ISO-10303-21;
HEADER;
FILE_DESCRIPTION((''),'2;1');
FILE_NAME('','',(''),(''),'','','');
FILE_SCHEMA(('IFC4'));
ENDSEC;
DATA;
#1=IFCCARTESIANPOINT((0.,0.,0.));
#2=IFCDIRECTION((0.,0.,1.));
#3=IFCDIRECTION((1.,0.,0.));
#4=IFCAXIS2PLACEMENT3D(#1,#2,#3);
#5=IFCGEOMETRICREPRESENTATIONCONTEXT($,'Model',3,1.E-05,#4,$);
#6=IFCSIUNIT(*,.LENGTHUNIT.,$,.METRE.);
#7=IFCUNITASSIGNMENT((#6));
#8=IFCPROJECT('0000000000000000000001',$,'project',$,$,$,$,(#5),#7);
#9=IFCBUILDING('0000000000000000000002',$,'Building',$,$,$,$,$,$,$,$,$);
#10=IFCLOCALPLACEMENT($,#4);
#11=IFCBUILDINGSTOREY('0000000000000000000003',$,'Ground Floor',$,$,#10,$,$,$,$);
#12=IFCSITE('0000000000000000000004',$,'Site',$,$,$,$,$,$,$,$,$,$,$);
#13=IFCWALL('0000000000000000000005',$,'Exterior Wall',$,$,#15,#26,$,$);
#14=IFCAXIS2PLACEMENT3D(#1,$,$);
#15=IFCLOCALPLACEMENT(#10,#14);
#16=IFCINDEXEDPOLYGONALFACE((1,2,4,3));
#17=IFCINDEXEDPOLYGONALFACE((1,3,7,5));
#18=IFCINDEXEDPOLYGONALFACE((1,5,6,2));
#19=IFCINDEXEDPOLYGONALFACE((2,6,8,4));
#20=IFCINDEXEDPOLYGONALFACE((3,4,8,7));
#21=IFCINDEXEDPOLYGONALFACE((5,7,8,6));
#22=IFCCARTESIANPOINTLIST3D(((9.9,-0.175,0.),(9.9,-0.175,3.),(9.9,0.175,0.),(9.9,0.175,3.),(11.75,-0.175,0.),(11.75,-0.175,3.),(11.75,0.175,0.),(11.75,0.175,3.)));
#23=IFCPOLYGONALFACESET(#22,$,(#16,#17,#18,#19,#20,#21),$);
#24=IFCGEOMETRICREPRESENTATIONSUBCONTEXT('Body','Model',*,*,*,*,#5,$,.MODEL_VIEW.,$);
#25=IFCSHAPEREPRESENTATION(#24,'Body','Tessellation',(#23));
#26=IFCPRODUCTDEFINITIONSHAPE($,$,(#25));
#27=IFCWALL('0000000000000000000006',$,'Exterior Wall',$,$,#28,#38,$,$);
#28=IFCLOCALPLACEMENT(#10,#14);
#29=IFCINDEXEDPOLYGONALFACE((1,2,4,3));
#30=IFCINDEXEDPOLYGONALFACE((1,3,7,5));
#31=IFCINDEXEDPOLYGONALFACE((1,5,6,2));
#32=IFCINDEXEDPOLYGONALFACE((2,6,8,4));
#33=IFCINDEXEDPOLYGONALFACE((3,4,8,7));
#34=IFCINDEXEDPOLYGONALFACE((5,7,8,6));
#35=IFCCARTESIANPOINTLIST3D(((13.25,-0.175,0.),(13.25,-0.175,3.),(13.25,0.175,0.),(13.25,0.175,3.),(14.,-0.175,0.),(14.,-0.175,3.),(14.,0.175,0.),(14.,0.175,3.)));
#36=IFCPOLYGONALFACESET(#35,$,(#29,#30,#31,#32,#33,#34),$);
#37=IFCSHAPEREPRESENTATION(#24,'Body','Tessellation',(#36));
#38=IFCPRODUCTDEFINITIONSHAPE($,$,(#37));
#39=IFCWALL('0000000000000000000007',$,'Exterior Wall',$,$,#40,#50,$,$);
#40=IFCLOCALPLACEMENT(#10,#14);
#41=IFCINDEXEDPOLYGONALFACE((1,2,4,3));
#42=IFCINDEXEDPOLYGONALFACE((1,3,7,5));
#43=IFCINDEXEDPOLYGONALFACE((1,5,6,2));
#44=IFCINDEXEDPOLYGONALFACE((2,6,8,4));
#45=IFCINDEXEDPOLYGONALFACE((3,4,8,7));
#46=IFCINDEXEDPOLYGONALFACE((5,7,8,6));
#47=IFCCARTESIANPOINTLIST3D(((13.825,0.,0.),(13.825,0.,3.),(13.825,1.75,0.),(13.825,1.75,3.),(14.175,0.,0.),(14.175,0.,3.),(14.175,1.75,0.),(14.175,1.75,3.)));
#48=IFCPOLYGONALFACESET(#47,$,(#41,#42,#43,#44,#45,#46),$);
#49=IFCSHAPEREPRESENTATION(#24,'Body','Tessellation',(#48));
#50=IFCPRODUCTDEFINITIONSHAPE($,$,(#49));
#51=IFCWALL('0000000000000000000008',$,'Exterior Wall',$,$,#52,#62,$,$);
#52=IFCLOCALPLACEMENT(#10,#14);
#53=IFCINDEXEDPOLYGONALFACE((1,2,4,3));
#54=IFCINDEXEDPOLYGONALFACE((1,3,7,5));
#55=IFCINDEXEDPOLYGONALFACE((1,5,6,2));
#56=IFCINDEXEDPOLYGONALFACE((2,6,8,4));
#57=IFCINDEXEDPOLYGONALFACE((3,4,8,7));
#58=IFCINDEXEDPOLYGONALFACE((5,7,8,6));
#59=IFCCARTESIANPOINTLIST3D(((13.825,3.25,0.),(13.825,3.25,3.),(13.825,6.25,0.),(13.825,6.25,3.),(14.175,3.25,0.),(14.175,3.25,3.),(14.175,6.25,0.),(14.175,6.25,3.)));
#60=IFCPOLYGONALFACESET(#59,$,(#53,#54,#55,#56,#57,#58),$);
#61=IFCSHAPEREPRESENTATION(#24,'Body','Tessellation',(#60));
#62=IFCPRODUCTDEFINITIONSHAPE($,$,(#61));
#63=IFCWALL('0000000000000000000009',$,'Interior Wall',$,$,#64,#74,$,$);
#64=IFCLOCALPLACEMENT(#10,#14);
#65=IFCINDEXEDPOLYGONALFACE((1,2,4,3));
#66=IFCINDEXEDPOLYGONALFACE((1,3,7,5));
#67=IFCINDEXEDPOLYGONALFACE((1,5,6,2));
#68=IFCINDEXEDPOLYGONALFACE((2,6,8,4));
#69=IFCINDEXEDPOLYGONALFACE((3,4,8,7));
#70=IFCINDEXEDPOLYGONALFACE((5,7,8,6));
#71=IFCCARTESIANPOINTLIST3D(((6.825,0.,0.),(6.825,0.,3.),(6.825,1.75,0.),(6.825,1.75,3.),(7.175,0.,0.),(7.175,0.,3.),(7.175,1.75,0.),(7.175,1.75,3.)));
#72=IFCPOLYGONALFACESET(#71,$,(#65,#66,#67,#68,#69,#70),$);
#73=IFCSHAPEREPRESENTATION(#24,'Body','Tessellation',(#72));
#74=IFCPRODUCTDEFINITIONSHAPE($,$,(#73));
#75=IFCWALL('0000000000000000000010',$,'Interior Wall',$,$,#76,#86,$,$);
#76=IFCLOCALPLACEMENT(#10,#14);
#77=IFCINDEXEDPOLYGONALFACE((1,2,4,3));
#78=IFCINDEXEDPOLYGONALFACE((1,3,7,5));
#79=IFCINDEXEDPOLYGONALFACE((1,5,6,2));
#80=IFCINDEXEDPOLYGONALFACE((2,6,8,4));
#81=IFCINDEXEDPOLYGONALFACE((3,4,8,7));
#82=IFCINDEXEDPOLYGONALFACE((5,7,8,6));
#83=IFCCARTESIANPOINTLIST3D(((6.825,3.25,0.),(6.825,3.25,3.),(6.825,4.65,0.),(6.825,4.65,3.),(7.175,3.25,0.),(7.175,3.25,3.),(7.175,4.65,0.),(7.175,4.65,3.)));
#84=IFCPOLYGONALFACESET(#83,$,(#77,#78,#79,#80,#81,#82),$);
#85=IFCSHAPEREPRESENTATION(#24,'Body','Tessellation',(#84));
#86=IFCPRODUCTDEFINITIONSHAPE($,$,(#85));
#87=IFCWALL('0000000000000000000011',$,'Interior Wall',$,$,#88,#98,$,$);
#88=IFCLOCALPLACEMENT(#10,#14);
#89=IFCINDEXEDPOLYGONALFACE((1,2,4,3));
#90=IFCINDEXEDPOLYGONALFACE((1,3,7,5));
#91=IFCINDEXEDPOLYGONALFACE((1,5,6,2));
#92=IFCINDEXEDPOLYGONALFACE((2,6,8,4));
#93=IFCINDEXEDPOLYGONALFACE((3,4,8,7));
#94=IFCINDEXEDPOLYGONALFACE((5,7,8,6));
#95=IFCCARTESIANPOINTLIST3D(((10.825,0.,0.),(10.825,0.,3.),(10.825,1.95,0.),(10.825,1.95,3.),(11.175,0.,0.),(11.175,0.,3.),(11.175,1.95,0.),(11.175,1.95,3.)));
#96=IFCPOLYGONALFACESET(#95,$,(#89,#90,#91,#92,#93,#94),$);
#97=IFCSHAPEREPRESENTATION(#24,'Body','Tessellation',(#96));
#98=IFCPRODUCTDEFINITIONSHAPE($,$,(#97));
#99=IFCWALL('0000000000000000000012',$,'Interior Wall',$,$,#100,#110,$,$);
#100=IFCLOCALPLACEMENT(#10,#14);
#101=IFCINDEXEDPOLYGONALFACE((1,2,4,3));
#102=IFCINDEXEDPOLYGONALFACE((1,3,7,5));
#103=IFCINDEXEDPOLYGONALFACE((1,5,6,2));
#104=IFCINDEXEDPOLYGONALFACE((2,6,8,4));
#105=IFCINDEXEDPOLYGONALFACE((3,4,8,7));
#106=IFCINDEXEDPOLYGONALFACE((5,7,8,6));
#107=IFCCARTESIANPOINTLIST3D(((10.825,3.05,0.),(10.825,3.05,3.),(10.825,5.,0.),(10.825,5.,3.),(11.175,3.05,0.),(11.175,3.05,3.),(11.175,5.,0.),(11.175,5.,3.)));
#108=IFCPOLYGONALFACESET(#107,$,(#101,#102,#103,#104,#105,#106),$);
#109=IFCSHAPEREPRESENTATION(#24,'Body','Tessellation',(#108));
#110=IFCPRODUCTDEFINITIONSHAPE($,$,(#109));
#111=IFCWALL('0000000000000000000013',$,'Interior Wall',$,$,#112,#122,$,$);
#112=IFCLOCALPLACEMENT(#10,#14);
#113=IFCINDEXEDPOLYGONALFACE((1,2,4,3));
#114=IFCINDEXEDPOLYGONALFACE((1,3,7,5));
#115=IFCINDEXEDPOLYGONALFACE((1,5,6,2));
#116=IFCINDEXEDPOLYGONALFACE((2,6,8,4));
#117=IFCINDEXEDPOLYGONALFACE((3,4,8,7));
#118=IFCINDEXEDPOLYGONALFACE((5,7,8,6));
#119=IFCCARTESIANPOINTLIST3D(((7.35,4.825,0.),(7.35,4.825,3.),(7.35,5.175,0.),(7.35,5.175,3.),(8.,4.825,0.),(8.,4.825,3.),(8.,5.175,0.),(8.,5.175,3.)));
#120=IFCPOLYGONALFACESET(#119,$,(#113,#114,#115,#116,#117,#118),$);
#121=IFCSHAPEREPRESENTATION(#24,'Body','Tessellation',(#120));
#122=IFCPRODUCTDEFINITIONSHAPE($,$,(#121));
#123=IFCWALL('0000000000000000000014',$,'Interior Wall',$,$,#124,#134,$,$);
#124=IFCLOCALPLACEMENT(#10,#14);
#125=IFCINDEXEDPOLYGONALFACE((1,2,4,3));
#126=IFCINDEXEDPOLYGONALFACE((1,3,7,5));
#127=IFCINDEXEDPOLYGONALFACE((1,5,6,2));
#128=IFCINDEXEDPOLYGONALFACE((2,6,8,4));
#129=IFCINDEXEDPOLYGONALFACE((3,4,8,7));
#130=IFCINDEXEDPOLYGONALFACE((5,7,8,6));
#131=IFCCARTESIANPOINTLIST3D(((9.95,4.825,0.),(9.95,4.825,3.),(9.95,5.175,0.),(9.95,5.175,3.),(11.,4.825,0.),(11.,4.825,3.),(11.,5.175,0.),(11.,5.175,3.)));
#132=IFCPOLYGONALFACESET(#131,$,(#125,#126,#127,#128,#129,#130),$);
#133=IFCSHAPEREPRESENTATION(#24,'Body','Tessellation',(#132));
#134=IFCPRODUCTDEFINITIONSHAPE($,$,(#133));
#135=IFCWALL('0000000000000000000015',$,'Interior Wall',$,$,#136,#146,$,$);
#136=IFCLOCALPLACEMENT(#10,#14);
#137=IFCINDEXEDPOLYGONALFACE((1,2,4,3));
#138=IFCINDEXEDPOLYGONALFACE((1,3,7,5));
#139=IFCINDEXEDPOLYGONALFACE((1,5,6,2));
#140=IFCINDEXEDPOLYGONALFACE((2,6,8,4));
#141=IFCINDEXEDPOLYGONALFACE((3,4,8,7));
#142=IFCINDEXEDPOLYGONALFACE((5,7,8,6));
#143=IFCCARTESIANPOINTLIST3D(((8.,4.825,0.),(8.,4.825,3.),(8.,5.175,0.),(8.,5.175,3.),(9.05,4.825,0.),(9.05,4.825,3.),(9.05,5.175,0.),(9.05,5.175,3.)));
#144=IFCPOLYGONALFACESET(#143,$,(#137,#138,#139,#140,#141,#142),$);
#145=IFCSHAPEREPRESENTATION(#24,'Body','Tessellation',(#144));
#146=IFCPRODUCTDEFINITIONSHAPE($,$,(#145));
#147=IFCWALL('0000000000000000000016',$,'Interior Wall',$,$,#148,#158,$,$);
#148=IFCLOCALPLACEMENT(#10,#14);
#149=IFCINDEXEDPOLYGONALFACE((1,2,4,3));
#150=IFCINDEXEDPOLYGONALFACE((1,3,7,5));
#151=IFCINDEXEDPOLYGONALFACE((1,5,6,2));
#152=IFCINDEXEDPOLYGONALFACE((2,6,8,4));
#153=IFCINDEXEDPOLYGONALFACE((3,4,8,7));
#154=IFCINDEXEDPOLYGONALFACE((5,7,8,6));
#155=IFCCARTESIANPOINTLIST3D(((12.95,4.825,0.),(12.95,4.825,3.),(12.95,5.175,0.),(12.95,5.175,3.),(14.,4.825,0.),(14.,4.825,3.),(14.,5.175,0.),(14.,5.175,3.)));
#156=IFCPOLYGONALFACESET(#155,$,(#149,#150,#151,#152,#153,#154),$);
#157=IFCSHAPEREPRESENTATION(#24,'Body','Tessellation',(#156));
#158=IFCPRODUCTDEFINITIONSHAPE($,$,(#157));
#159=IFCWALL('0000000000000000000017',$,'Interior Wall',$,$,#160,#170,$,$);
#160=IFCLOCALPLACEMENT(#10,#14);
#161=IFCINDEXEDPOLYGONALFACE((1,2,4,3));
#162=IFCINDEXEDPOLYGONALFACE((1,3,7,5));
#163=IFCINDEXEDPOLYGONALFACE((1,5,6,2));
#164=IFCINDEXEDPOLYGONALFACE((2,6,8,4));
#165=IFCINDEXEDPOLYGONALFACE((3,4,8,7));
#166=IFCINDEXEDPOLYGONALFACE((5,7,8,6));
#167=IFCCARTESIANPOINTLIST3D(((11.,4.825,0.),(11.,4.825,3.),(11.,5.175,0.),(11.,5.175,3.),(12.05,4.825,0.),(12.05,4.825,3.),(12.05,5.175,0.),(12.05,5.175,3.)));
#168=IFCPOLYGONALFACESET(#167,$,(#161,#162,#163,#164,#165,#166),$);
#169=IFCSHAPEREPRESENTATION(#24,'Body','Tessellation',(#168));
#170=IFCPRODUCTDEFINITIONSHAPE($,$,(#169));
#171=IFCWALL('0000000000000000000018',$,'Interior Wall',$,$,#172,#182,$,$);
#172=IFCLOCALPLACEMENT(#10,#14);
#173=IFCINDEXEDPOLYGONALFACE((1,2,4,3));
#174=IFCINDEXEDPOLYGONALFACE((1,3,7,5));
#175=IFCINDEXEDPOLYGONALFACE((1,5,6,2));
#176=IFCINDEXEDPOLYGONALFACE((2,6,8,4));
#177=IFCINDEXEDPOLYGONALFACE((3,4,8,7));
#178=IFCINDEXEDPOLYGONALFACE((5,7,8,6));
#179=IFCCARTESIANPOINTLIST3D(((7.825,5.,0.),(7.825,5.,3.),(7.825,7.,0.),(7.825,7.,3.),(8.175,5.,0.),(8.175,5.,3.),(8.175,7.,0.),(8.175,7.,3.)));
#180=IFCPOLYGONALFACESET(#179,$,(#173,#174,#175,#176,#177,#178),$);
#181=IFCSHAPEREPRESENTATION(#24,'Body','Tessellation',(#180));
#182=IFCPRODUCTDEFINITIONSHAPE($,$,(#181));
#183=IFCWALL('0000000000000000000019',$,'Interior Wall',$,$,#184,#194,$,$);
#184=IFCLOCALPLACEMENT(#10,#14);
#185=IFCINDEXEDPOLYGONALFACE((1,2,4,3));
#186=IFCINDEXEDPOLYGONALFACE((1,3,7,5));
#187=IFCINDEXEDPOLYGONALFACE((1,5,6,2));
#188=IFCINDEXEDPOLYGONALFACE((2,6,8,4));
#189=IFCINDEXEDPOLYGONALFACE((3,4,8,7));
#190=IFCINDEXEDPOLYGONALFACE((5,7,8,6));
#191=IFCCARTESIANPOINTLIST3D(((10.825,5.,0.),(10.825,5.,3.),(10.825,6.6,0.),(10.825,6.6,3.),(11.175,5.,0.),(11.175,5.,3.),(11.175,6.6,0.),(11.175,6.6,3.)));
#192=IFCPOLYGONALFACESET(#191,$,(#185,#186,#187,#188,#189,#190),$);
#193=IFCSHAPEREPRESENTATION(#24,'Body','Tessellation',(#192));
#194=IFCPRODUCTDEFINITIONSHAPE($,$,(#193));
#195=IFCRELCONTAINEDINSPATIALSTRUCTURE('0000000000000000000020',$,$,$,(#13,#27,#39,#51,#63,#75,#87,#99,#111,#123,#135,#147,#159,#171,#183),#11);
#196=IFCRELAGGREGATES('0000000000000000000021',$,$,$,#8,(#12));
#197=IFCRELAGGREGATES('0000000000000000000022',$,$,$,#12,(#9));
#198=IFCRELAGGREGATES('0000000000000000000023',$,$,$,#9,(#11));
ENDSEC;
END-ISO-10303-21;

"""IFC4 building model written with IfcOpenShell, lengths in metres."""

from ifc_helpers import new_model, si_unit, frame, origin_with_axes, place, context, subcontext, project, spatial, indexed_curve, outline, extrude, element, save


model = new_model("IFC4")

# Units and contexts
model_context = context("Model", 3, precision=1e-05, world=origin_with_axes())
body_context = subcontext(model_context, "Body", "Model", "MODEL_VIEW")
ifc_project = project(units=[si_unit("LENGTHUNIT", "METRE")], contexts=[model_context])

# Site, building, storey
site = spatial("IfcSite", under=ifc_project, Name="Site")
building = spatial("IfcBuilding", under=site, Name="Building")
storey_placement = place(None, origin_with_axes())
storey = spatial("IfcBuildingStorey", under=building, at=storey_placement, Name="Ground Floor")

# Walls
wall_1_placement = place(storey_placement, frame((9.9, 0.0, 0.0), z_axis=(0.0, 0.0, 1.0), x_axis=(1.0, 0.0, 0.0)))
element("IfcWall", 1, at=wall_1_placement, inside=storey, Name="Exterior Wall", context=body_context, shape_type="SweptSolid", body=[
    extrude(outline(indexed_curve([(0.0, 0.0), (0.0, 0.35), (1.85, 0.35), (1.85, 0.0), (0.0, 0.0)], self_intersect=False)), frame((0.0, -0.175, 0.0), z_axis=(0.0, 0.0, 1.0), x_axis=(1.0, 0.0, 0.0)), (0.0, 0.0, 1.0), 3.0),
])
wall_2_placement = place(storey_placement, frame((13.25, 0.0, 0.0), z_axis=(0.0, 0.0, 1.0), x_axis=(1.0, 0.0, 0.0)))
element("IfcWall", 2, at=wall_2_placement, inside=storey, Name="Exterior Wall", context=body_context, shape_type="SweptSolid", body=[
    extrude(outline(indexed_curve([(0.0, 0.0), (0.0, 0.35), (0.75, 0.35), (0.75, 0.0), (0.0, 0.0)], self_intersect=False)), frame((0.0, -0.175, 0.0), z_axis=(0.0, 0.0, 1.0), x_axis=(1.0, 0.0, 0.0)), (0.0, 0.0, 1.0), 3.0),
])
wall_3_placement = place(storey_placement, frame((14.0, 0.0, 0.0), z_axis=(0.0, 0.0, 1.0), x_axis=(0.0, 1.0, 0.0)))
element("IfcWall", 3, at=wall_3_placement, inside=storey, Name="Exterior Wall", context=body_context, shape_type="SweptSolid", body=[
    extrude(outline(indexed_curve([(0.0, 0.0), (0.0, 0.35), (1.75, 0.35), (1.75, 0.0), (0.0, 0.0)], self_intersect=False)), frame((0.0, -0.175, 0.0), z_axis=(0.0, 0.0, 1.0), x_axis=(1.0, 0.0, 0.0)), (0.0, 0.0, 1.0), 3.0),
])
wall_4_placement = place(storey_placement, frame((14.0, 3.25, 0.0), z_axis=(0.0, 0.0, 1.0), x_axis=(0.0, 1.0, 0.0)))
element("IfcWall", 4, at=wall_4_placement, inside=storey, Name="Exterior Wall", context=body_context, shape_type="SweptSolid", body=[
    extrude(outline(indexed_curve([(0.0, 0.0), (0.0, 0.35), (3.0, 0.35), (3.0, 0.0), (0.0, 0.0)], self_intersect=False)), frame((0.0, -0.175, 0.0), z_axis=(0.0, 0.0, 1.0), x_axis=(1.0, 0.0, 0.0)), (0.0, 0.0, 1.0), 3.0),
])
wall_5_placement = place(storey_placement, frame((7.0, 0.0, 0.0), z_axis=(0.0, 0.0, 1.0), x_axis=(0.0, 1.0, 0.0)))
element("IfcWall", 5, at=wall_5_placement, inside=storey, Name="Interior Wall", context=body_context, shape_type="SweptSolid", body=[
    extrude(outline(indexed_curve([(0.0, 0.0), (0.0, 0.35), (1.75, 0.35), (1.75, 0.0), (0.0, 0.0)], self_intersect=False)), frame((0.0, -0.175, 0.0), z_axis=(0.0, 0.0, 1.0), x_axis=(1.0, 0.0, 0.0)), (0.0, 0.0, 1.0), 3.0),
])
wall_6_placement = place(storey_placement, frame((7.0, 3.25, 0.0), z_axis=(0.0, 0.0, 1.0), x_axis=(0.0, 1.0, 0.0)))
element("IfcWall", 6, at=wall_6_placement, inside=storey, Name="Interior Wall", context=body_context, shape_type="SweptSolid", body=[
    extrude(outline(indexed_curve([(0.0, 0.0), (0.0, 0.35), (1.4, 0.35), (1.4, 0.0), (0.0, 0.0)], self_intersect=False)), frame((0.0, -0.175, 0.0), z_axis=(0.0, 0.0, 1.0), x_axis=(1.0, 0.0, 0.0)), (0.0, 0.0, 1.0), 3.0),
])
wall_7_placement = place(storey_placement, frame((11.0, 0.0, 0.0), z_axis=(0.0, 0.0, 1.0), x_axis=(0.0, 1.0, 0.0)))
element("IfcWall", 7, at=wall_7_placement, inside=storey, Name="Interior Wall", context=body_context, shape_type="SweptSolid", body=[
    extrude(outline(indexed_curve([(0.0, 0.0), (0.0, 0.35), (1.95, 0.35), (1.95, 0.0), (0.0, 0.0)], self_intersect=False)), frame((0.0, -0.175, 0.0), z_axis=(0.0, 0.0, 1.0), x_axis=(1.0, 0.0, 0.0)), (0.0, 0.0, 1.0), 3.0),
])
wall_8_placement = place(storey_placement, frame((11.0, 3.05, 0.0), z_axis=(0.0, 0.0, 1.0), x_axis=(0.0, 1.0, 0.0)))
element("IfcWall", 8, at=wall_8_placement, inside=storey, Name="Interior Wall", context=body_context, shape_type="SweptSolid", body=[
    extrude(outline(indexed_curve([(0.0, 0.0), (0.0, 0.35), (1.95, 0.35), (1.95, 0.0), (0.0, 0.0)], self_intersect=False)), frame((0.0, -0.175, 0.0), z_axis=(0.0, 0.0, 1.0), x_axis=(1.0, 0.0, 0.0)), (0.0, 0.0, 1.0), 3.0),
])
wall_9_placement = place(storey_placement, frame((8.0, 5.0, 0.0), z_axis=(0.0, 0.0, 1.0), x_axis=(-1.0, 0.0, 0.0)))
element("IfcWall", 9, at=wall_9_placement, inside=storey, Name="Interior Wall", context=body_context, shape_type="SweptSolid", body=[
    extrude(outline(indexed_curve([(0.0, 0.0), (0.0, 0.35), (0.65, 0.35), (0.65, 0.0), (0.0, 0.0)], self_intersect=False)), frame((0.0, -0.175, 0.0), z_axis=(0.0, 0.0, 1.0), x_axis=(1.0, 0.0, 0.0)), (0.0, 0.0, 1.0), 3.0),
])
for number, where, z_axis, x_axis, name in (
    (10, (11.0, 5.0, 0.0), (0.0, 0.0, 1.0), (-1.0, 0.0, 0.0), "Interior Wall"),
    (11, (9.05, 5.0, 0.0), (0.0, 0.0, 1.0), (-1.0, 0.0, 0.0), "Interior Wall"),
    (12, (14.0, 5.0, 0.0), (0.0, 0.0, 1.0), (-1.0, 0.0, 0.0), "Interior Wall"),
    (13, (12.05, 5.0, 0.0), (0.0, 0.0, 1.0), (-1.0, 0.0, 0.0), "Interior Wall"),
):
    element("IfcWall", number, at=place(storey_placement, frame(where, z_axis=z_axis, x_axis=x_axis)), inside=storey, Name=name, context=body_context, shape_type="SweptSolid", body=[
        extrude(outline(indexed_curve([(0.0, 0.0), (0.0, 0.35), (1.05, 0.35), (1.05, 0.0), (0.0, 0.0)], self_intersect=False)), frame((0.0, -0.175, 0.0), z_axis=(0.0, 0.0, 1.0), x_axis=(1.0, 0.0, 0.0)), (0.0, 0.0, 1.0), 3.0),
    ])
wall_10_placement = place(storey_placement, frame((8.0, 5.0, 0.0), z_axis=(0.0, 0.0, 1.0), x_axis=(0.0, 1.0, 0.0)))
element("IfcWall", 14, at=wall_10_placement, inside=storey, Name="Interior Wall", context=body_context, shape_type="SweptSolid", body=[
    extrude(outline(indexed_curve([(0.0, 0.0), (0.0, 0.35), (2.0, 0.35), (2.0, 0.0), (0.0, 0.0)], self_intersect=False)), frame((0.0, -0.175, 0.0), z_axis=(0.0, 0.0, 1.0), x_axis=(1.0, 0.0, 0.0)), (0.0, 0.0, 1.0), 3.0),
])
wall_11_placement = place(storey_placement, frame((11.0, 5.0, 0.0), z_axis=(0.0, 0.0, 1.0), x_axis=(0.0, 1.0, 0.0)))
element("IfcWall", 15, at=wall_11_placement, inside=storey, Name="Interior Wall", context=body_context, shape_type="SweptSolid", body=[
    extrude(outline(indexed_curve([(0.0, 0.0), (0.0, 0.35), (1.6, 0.35), (1.6, 0.0), (0.0, 0.0)], self_intersect=False)), frame((0.0, -0.175, 0.0), z_axis=(0.0, 0.0, 1.0), x_axis=(1.0, 0.0, 0.0)), (0.0, 0.0, 1.0), 3.0),
])

save(model, "model.ifc")
